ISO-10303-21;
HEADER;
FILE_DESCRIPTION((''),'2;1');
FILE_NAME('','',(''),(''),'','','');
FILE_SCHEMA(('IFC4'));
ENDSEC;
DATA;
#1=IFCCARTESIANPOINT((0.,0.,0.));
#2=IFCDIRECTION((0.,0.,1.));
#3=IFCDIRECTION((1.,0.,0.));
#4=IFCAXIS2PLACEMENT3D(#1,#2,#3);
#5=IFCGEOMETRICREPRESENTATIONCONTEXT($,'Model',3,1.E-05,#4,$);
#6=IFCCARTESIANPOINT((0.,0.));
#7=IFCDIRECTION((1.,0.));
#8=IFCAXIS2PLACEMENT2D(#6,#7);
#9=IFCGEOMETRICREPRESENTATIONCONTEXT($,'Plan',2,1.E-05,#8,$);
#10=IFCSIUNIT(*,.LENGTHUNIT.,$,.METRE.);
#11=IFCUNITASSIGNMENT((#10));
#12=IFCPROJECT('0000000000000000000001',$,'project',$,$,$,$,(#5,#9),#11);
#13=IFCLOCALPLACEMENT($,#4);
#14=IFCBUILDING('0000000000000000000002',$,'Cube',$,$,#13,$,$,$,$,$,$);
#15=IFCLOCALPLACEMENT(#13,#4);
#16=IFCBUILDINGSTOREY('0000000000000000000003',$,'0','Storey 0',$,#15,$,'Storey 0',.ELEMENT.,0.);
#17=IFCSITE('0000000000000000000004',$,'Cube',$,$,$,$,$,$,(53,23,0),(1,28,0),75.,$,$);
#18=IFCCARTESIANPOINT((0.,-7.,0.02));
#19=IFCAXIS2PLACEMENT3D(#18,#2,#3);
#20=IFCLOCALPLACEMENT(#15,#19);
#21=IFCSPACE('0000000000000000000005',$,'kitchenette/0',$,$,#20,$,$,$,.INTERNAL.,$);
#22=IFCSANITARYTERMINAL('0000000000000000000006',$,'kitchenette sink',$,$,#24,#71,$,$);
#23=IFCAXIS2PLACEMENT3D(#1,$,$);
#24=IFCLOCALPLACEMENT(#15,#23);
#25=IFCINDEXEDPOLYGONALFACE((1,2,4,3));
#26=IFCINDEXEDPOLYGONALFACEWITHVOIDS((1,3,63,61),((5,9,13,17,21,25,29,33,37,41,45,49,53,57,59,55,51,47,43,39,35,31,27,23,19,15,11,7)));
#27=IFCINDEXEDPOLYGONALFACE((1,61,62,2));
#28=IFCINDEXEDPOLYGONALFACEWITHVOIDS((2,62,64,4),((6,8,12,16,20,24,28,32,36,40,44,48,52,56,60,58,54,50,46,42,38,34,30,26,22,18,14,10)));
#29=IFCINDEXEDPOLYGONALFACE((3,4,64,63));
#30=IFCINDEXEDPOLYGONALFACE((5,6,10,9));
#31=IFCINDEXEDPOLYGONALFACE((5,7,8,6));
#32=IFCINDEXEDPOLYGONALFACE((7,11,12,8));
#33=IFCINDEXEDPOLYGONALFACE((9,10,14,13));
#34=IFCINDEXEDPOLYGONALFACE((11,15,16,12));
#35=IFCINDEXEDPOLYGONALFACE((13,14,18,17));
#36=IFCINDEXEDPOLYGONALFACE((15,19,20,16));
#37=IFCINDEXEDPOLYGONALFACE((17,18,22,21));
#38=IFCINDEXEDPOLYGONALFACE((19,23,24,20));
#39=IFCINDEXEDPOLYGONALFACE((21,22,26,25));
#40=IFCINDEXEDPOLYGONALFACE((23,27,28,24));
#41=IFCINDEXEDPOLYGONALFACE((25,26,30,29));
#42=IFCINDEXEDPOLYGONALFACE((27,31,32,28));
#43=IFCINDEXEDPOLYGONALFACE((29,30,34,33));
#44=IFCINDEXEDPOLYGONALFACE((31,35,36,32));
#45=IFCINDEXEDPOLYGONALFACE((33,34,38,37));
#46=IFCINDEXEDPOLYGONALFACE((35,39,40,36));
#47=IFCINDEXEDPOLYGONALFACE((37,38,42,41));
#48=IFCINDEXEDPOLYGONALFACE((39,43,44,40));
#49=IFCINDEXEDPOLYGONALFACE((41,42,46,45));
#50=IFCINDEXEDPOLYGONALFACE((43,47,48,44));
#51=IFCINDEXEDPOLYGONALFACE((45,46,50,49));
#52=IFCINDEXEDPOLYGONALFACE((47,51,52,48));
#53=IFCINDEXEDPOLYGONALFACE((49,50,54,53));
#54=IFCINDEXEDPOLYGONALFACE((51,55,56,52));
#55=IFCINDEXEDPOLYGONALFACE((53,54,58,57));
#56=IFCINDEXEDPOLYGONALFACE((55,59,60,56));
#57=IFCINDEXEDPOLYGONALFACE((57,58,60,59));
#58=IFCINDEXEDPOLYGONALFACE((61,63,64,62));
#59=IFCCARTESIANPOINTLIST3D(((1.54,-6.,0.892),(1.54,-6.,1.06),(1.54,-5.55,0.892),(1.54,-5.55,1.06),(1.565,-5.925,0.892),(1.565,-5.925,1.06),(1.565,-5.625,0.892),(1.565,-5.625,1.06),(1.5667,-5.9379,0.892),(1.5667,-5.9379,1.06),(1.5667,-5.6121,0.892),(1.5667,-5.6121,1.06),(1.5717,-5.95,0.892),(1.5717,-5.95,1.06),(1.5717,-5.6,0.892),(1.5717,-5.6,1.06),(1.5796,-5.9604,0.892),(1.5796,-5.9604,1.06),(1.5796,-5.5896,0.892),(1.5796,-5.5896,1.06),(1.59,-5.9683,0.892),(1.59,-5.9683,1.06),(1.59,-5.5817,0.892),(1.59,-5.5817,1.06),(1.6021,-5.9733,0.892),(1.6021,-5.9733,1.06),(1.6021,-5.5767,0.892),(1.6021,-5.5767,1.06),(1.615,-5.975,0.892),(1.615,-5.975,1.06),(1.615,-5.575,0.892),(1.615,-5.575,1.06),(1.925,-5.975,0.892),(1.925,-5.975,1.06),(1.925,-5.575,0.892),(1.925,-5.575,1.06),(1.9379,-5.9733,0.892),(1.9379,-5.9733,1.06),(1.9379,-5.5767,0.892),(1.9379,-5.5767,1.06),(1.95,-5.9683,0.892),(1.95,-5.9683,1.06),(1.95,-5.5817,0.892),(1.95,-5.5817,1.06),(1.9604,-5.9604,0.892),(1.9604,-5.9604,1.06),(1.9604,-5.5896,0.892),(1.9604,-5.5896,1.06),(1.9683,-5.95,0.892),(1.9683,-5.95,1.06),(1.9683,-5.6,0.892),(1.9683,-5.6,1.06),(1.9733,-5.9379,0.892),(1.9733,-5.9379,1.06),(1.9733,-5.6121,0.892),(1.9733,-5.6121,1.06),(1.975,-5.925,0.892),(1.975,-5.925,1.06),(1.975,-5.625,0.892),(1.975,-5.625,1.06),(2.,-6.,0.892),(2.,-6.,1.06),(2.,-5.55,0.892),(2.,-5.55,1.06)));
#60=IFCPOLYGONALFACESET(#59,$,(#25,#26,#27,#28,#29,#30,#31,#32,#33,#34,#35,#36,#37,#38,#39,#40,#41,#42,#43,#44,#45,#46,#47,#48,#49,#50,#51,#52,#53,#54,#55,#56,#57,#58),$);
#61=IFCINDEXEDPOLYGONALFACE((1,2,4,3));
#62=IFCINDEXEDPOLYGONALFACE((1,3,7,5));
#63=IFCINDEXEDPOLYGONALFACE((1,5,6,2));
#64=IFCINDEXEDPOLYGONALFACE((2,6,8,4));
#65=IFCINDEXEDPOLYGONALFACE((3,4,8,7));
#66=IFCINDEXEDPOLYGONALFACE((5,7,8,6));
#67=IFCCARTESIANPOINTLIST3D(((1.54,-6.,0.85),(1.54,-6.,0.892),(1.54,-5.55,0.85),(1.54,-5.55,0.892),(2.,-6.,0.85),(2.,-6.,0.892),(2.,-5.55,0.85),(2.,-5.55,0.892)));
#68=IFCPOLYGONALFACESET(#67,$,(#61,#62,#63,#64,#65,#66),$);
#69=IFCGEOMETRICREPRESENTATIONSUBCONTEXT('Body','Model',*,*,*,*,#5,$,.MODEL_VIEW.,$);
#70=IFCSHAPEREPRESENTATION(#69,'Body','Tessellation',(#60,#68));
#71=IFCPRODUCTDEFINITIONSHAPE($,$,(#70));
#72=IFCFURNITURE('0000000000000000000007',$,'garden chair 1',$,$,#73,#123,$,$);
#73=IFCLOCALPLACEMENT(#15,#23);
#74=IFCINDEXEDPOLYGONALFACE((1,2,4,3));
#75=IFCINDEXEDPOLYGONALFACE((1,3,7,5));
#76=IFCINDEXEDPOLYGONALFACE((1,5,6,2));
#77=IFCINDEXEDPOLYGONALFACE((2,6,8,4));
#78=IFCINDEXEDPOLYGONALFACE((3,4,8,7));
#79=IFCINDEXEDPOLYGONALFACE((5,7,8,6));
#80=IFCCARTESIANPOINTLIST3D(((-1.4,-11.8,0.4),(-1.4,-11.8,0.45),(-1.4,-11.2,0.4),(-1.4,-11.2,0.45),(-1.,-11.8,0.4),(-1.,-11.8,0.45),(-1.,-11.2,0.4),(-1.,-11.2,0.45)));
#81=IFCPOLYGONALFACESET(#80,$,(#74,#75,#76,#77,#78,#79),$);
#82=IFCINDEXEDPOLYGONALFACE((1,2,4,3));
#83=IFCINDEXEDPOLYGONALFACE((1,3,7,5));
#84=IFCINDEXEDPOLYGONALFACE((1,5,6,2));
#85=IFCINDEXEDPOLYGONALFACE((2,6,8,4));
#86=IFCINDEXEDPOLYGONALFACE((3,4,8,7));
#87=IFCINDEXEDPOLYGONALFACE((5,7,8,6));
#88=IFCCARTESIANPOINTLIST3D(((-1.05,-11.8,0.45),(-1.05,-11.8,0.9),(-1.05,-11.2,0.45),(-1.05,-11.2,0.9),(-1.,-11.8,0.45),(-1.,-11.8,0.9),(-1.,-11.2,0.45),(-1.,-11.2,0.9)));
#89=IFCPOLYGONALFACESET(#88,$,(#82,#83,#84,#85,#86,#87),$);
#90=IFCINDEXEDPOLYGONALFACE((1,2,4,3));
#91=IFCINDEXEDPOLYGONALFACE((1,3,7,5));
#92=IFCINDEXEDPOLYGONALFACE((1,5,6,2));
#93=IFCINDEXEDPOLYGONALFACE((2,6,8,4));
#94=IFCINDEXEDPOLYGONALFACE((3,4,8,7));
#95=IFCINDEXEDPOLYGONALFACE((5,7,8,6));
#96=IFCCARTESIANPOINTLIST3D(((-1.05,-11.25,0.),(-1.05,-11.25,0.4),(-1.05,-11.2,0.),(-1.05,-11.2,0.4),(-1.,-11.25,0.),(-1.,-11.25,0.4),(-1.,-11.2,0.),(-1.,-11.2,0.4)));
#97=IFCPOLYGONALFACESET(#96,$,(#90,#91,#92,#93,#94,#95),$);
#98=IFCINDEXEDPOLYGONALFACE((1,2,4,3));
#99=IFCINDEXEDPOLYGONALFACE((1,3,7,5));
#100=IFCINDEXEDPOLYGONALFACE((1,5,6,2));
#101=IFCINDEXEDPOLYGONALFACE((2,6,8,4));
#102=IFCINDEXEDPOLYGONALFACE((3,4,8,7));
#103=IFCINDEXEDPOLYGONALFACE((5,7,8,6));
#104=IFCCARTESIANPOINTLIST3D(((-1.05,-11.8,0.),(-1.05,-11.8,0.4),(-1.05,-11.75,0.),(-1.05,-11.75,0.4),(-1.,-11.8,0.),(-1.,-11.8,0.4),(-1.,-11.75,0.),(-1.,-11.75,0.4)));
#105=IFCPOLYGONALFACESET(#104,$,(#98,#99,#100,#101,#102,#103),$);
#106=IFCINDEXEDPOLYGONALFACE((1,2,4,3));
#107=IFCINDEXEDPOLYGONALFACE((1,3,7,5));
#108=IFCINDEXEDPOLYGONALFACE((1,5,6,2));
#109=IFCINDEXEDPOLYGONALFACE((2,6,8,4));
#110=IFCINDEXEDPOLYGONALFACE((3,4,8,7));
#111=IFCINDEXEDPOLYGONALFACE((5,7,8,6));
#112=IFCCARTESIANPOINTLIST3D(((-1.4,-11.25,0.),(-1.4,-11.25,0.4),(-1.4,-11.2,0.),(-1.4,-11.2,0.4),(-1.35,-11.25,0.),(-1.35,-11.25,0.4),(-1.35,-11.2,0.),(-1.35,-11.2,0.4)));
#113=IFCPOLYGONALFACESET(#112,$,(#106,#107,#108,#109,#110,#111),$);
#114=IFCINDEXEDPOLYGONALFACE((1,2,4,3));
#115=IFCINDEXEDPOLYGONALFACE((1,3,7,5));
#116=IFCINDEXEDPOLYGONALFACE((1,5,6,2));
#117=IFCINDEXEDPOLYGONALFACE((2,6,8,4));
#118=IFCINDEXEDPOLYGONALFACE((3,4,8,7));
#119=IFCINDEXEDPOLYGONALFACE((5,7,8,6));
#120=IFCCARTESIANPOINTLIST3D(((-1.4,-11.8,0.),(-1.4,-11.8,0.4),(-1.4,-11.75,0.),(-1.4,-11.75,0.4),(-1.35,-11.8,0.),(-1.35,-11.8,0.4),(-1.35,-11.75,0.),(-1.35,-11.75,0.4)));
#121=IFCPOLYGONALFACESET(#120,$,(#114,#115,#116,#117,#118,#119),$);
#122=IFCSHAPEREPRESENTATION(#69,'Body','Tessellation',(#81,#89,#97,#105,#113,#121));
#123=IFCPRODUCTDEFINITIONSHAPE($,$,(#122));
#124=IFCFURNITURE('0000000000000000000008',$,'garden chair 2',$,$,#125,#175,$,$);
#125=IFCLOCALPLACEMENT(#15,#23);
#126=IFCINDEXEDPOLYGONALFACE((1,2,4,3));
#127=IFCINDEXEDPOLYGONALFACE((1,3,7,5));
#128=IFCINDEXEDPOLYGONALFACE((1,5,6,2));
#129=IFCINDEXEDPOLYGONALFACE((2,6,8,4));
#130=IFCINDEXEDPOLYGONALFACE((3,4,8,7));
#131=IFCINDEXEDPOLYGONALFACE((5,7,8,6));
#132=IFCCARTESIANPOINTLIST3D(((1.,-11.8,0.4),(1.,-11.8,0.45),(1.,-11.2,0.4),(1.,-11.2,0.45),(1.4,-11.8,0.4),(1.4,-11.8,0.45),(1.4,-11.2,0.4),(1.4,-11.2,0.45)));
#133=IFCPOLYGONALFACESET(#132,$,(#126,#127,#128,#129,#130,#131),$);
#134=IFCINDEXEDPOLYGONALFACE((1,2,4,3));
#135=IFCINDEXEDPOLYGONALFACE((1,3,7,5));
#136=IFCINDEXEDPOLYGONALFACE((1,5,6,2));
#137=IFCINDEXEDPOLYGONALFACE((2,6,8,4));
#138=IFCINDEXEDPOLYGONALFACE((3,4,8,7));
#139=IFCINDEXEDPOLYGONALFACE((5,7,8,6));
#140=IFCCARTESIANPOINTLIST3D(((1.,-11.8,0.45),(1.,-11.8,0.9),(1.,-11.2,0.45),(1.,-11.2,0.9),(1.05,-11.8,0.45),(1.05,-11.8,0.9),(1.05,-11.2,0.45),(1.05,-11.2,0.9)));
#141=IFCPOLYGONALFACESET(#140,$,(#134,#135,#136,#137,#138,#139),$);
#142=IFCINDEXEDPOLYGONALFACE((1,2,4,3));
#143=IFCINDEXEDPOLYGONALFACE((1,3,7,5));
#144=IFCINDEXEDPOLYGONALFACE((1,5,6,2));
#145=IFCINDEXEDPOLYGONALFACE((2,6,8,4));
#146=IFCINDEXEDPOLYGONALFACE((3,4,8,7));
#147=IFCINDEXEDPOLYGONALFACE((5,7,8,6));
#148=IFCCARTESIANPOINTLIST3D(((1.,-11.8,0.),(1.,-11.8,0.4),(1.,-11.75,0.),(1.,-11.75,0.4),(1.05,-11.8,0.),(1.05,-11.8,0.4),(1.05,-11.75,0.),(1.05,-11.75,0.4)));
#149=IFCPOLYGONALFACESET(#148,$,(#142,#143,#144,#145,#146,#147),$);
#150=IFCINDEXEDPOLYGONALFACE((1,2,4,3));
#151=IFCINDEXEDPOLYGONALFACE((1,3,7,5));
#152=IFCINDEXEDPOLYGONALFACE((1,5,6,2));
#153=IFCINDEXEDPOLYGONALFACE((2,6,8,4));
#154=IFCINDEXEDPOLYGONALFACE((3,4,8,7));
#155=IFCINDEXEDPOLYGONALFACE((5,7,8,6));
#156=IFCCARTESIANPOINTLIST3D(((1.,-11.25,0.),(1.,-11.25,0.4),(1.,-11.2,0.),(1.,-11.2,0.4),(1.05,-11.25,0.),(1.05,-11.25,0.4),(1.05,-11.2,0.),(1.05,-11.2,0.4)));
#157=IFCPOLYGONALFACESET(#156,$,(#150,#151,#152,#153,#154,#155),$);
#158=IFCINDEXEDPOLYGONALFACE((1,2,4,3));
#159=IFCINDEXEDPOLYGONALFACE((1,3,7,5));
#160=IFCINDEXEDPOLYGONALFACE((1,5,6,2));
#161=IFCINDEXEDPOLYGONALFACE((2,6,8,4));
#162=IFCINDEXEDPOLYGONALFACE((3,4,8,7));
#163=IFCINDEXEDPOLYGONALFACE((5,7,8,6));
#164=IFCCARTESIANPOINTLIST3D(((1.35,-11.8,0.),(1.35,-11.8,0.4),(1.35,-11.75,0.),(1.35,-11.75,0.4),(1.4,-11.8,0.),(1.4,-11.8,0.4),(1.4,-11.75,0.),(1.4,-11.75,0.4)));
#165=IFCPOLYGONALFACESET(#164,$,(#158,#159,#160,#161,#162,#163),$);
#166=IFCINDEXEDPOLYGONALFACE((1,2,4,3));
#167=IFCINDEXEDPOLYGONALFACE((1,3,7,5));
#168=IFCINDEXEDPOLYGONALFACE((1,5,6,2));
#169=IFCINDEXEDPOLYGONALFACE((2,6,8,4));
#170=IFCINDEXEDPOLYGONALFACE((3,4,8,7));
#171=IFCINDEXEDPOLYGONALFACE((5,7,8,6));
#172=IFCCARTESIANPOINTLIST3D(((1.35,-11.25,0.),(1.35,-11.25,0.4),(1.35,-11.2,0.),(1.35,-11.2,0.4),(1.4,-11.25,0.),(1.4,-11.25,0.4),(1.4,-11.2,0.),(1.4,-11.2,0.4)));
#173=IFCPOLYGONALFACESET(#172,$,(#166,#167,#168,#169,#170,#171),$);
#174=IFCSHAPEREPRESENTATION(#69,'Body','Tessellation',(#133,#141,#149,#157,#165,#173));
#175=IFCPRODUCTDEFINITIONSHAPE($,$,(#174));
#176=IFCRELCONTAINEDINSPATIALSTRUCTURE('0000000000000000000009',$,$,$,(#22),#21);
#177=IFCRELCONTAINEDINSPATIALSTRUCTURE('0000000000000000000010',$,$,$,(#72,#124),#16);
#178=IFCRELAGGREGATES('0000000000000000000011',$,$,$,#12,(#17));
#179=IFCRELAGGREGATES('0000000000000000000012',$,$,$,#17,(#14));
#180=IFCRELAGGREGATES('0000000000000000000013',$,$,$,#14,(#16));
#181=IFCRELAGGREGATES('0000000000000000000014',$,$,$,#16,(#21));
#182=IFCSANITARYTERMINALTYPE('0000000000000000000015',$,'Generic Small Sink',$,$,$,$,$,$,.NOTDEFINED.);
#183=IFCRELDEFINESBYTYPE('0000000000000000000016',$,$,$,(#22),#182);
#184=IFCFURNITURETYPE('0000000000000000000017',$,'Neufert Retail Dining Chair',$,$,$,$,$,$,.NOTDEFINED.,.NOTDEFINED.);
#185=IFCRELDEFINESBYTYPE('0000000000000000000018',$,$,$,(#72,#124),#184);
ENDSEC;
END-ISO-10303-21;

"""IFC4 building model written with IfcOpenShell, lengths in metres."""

from ifc_helpers import new_model, entity, si_unit, frame, origin_with_axes, origin_2d_with_axis, place, context, subcontext, project, spatial, line, indexed_curve, outline, extrude, shape, source, transform, mapped, type_object, type_shapes, element, save


model = new_model("IFC4")

# Units and contexts
model_context = context("Model", 3, precision=1e-05, world=origin_with_axes())
plan_context = context("Plan", 2, precision=1e-05, world=origin_2d_with_axis())
body_context_1 = subcontext(model_context, "Body", "Model", "MODEL_VIEW")
body_context_2 = subcontext(plan_context, "Body", "Plan", "PLAN_VIEW")
ifc_project = project(units=[si_unit("LENGTHUNIT", "METRE")], contexts=[model_context, plan_context])

# Site, building, storey
site = spatial("IfcSite", under=ifc_project, Name="Cube", RefLatitude=(53, 23, 0), RefLongitude=(1, 28, 0), RefElevation=75.0)
building_placement = place(None, origin_with_axes())
building = spatial("IfcBuilding", under=site, at=building_placement, Name="Cube")
storey_placement = place(building_placement, origin_with_axes())
storey = spatial("IfcBuildingStorey", under=building, at=storey_placement, Name="0", Description="Storey 0", LongName="Storey 0", CompositionType="ELEMENT", Elevation=0.0)

# Shared definitions
space_1_placement = place(storey_placement, frame((0.0, -7.0, 0.02), z_axis=(0.0, 0.0, 1.0), x_axis=(1.0, 0.0, 0.0)))
space_1 = spatial("IfcSpace", under=storey, at=space_1_placement, Name="kitchenette/0", PredefinedType="INTERNAL")

# Sanitary terminal
sanitary_terminal_type_1 = type_object("IfcSanitaryTerminalType", Name="Generic Small Sink", PredefinedType="NOTDEFINED")
shared_indexed_poly_curve_1 = entity("IfcIndexedPolyCurve", entity("IfcCartesianPointList2D", [[0.0, 0.0], [0.45, 0.0], [0.45, 0.46], [0.0, 0.46]]), [entity("IfcLineIndex", [1, 2, 3, 4, 1])])
shared_shape_1 = source(origin_with_axes(), body_context_1, "Body", "SweptSolid", [
    entity("IfcExtrudedAreaSolid", entity("IfcArbitraryProfileDefWithVoids", "AREA", None, shared_indexed_poly_curve_1, [entity("IfcIndexedPolyCurve", entity("IfcCartesianPointList2D", [[0.025, 0.075], [0.0396, 0.0396], [0.075, 0.025], [0.375, 0.025], [0.4104, 0.0396], [0.425, 0.075], [0.425, 0.385], [0.4104, 0.4204], [0.375, 0.435], [0.075, 0.435], [0.0396, 0.4204], [0.025, 0.385]]), [entity("IfcLineIndex", [12, 1]), entity("IfcArcIndex", [1, 2, 3]), entity("IfcLineIndex", [3, 4]), entity("IfcArcIndex", [4, 5, 6]), entity("IfcLineIndex", [6, 7]), entity("IfcArcIndex", [7, 8, 9]), entity("IfcLineIndex", [9, 10]), entity("IfcArcIndex", [10, 11, 12]), entity("IfcLineIndex", [12, 1])])]), entity("IfcAxis2Placement3D", entity("IfcCartesianPoint", [-0.225, -0.46, 0.042]), entity("IfcDirection", [0.0, 0.0, 1.0]), entity("IfcDirection", [1.0, 0.0, 0.0])), entity("IfcDirection", [0.0, 0.0, 1.0]), 0.168),
    entity("IfcExtrudedAreaSolid", entity("IfcArbitraryClosedProfileDef", "AREA", None, shared_indexed_poly_curve_1), entity("IfcAxis2Placement3D", entity("IfcCartesianPoint", [-0.225, -0.46, 0.0]), entity("IfcDirection", [0.0, 0.0, 1.0]), entity("IfcDirection", [1.0, 0.0, 0.0])), entity("IfcDirection", [0.0, 0.0, 1.0]), 0.042),
])
shared_shape_2 = source(origin_with_axes(), body_context_2, "Body", "Curve2D", [
    entity("IfcIndexedPolyCurve", entity("IfcCartesianPointList2D", [[-0.225, -0.46], [0.225, -0.46], [0.225, 0.0], [-0.225, 0.0]]), [entity("IfcLineIndex", [1, 2, 3, 4, 1])]),
    entity("IfcIndexedPolyCurve", entity("IfcCartesianPointList2D", [[-0.2, -0.385], [-0.1854, -0.4204], [-0.15, -0.435], [0.15, -0.435], [0.1854, -0.4204], [0.2, -0.385], [0.2, -0.075], [0.1854, -0.0396], [0.15, -0.025], [-0.15, -0.025], [-0.1854, -0.0396], [-0.2, -0.075]]), [entity("IfcLineIndex", [12, 1]), entity("IfcArcIndex", [1, 2, 3]), entity("IfcLineIndex", [3, 4]), entity("IfcArcIndex", [4, 5, 6]), entity("IfcLineIndex", [6, 7]), entity("IfcArcIndex", [7, 8, 9]), entity("IfcLineIndex", [9, 10]), entity("IfcArcIndex", [10, 11, 12]), entity("IfcLineIndex", [12, 1])]),
    entity("IfcCircle", entity("IfcAxis2Placement2D", entity("IfcCartesianPoint", [0.0, -0.125])), 0.025),
    entity("IfcIndexedPolyCurve", entity("IfcCartesianPointList2D", [[0.0, -0.0125], [0.0, -0.1325]])),
])
type_shapes(sanitary_terminal_type_1, [shared_shape_1, shared_shape_2])
sanitary_terminal_1_placement = place(space_1_placement, frame((2.0, 1.225, 0.83), z_axis=(0.0, 0.0, 1.0), x_axis=(0.0, -1.0, 0.0)))
element("IfcSanitaryTerminal", 1, at=sanitary_terminal_1_placement, inside=space_1, type_object=sanitary_terminal_type_1, Name="kitchenette sink", shapes=[
    shape(body_context_1, "Body", "MappedRepresentation", [mapped(shared_shape_1, transform((0.0, 0.0, 0.0), x_axis=(1.0, 0.0, 0.0), y_axis=(0.0, 1.0, 0.0), z_axis=(0.0, 0.0, 1.0), scale=1.0))]),
    shape(body_context_2, "Body", "MappedRepresentation", [mapped(shared_shape_2, transform((0.0, 0.0, 0.0), x_axis=(1.0, 0.0, 0.0), y_axis=(0.0, 1.0, 0.0), z_axis=(0.0, 0.0, 1.0), scale=1.0))]),
])

# Furniture
furniture_type_1 = type_object("IfcFurnitureType", Name="Neufert Retail Dining Chair", AssemblyPlace="NOTDEFINED", PredefinedType="NOTDEFINED")
shared_shape_3 = source(origin_with_axes(), body_context_1, "Body", "SweptSolid", [
    extrude(outline(indexed_curve([(-0.3, 0.0), (0.3, 0.0), (0.3, -0.4), (-0.3, -0.4)], segments=[line(1, 2, 3, 4, 1)])), frame((0.0, 0.0, 0.45), z_axis=(0.0, 0.0, 1.0), x_axis=(1.0, 0.0, 0.0)), (0.0, 0.0, -1.0), 0.05),
    extrude(outline(indexed_curve([(-0.3, 0.0), (0.3, 0.0), (0.3, -0.05), (-0.3, -0.05)], segments=[line(1, 2, 3, 4, 1)])), frame((0.0, 0.0, 0.9), z_axis=(0.0, 0.0, 1.0), x_axis=(1.0, 0.0, 0.0)), (0.0, 0.0, -1.0), 0.45),
    extrude(outline(indexed_curve([(-0.3, 0.0), (-0.25, 0.0), (-0.25, -0.05), (-0.3, -0.05)], segments=[line(1, 2, 3, 4, 1)])), origin_with_axes(), (0.0, 0.0, 1.0), 0.4),
    extrude(outline(indexed_curve([(0.3, 0.0), (0.25, 0.0), (0.25, -0.05), (0.3, -0.05)], segments=[line(1, 2, 3, 4, 1)])), origin_with_axes(), (0.0, 0.0, 1.0), 0.4),
    extrude(outline(indexed_curve([(-0.3, -0.4), (-0.25, -0.4), (-0.25, -0.35), (-0.3, -0.35)], segments=[line(1, 2, 3, 4, 1)])), origin_with_axes(), (0.0, 0.0, 1.0), 0.4),
    extrude(outline(indexed_curve([(0.3, -0.4), (0.25, -0.4), (0.25, -0.35), (0.3, -0.35)], segments=[line(1, 2, 3, 4, 1)])), origin_with_axes(), (0.0, 0.0, 1.0), 0.4),
])
shared_shape_4 = source(origin_with_axes(), body_context_2, "Body", "Curve2D", [
    entity("IfcIndexedPolyCurve", entity("IfcCartesianPointList2D", [[-0.3, -0.4], [0.3, -0.4]])),
    entity("IfcIndexedPolyCurve", entity("IfcCartesianPointList2D", [[-0.3, -0.4], [-0.3, -0.3], [-0.2121, -0.0879], [0.0, 0.0], [0.2121, -0.0879], [0.3, -0.3], [0.3, -0.4]]), [entity("IfcLineIndex", [1, 2]), entity("IfcArcIndex", [2, 3, 4]), entity("IfcArcIndex", [4, 5, 6]), entity("IfcLineIndex", [6, 7])]),
    entity("IfcIndexedPolyCurve", entity("IfcCartesianPointList2D", [[-0.26, -0.4], [-0.26, -0.3], [-0.1838, -0.1162], [0.0, -0.04], [0.1838, -0.1162], [0.26, -0.3], [0.26, -0.4]]), [entity("IfcLineIndex", [1, 2]), entity("IfcArcIndex", [2, 3, 4]), entity("IfcArcIndex", [4, 5, 6]), entity("IfcLineIndex", [6, 7])]),
])
type_shapes(furniture_type_1, [shared_shape_3, shared_shape_4])
for number, where, z_axis, x_axis, name in (
    (2, (-1.0, -11.5, 0.0), (0.0, 0.0, 1.0), (0.0, -1.0, 0.0), "garden chair 1"),
    (3, (1.0, -11.5, 0.0), (0.0, 0.0, 1.0), (0.0, 1.0, 0.0), "garden chair 2"),
):
    element("IfcFurniture", number, at=place(storey_placement, frame(where, z_axis=z_axis, x_axis=x_axis)), inside=storey, type_object=furniture_type_1, Name=name, shapes=[
        shape(body_context_1, "Body", "MappedRepresentation", [mapped(shared_shape_3, transform((0.0, 0.0, 0.0), x_axis=(1.0, 0.0, 0.0), y_axis=(0.0, 1.0, 0.0), z_axis=(0.0, 0.0, 1.0), scale=1.0))]),
        shape(body_context_2, "Body", "MappedRepresentation", [mapped(shared_shape_4, transform((0.0, 0.0, 0.0), x_axis=(1.0, 0.0, 0.0), y_axis=(0.0, 1.0, 0.0), z_axis=(0.0, 0.0, 1.0), scale=1.0))]),
    ])

save(model, "model.ifc")
